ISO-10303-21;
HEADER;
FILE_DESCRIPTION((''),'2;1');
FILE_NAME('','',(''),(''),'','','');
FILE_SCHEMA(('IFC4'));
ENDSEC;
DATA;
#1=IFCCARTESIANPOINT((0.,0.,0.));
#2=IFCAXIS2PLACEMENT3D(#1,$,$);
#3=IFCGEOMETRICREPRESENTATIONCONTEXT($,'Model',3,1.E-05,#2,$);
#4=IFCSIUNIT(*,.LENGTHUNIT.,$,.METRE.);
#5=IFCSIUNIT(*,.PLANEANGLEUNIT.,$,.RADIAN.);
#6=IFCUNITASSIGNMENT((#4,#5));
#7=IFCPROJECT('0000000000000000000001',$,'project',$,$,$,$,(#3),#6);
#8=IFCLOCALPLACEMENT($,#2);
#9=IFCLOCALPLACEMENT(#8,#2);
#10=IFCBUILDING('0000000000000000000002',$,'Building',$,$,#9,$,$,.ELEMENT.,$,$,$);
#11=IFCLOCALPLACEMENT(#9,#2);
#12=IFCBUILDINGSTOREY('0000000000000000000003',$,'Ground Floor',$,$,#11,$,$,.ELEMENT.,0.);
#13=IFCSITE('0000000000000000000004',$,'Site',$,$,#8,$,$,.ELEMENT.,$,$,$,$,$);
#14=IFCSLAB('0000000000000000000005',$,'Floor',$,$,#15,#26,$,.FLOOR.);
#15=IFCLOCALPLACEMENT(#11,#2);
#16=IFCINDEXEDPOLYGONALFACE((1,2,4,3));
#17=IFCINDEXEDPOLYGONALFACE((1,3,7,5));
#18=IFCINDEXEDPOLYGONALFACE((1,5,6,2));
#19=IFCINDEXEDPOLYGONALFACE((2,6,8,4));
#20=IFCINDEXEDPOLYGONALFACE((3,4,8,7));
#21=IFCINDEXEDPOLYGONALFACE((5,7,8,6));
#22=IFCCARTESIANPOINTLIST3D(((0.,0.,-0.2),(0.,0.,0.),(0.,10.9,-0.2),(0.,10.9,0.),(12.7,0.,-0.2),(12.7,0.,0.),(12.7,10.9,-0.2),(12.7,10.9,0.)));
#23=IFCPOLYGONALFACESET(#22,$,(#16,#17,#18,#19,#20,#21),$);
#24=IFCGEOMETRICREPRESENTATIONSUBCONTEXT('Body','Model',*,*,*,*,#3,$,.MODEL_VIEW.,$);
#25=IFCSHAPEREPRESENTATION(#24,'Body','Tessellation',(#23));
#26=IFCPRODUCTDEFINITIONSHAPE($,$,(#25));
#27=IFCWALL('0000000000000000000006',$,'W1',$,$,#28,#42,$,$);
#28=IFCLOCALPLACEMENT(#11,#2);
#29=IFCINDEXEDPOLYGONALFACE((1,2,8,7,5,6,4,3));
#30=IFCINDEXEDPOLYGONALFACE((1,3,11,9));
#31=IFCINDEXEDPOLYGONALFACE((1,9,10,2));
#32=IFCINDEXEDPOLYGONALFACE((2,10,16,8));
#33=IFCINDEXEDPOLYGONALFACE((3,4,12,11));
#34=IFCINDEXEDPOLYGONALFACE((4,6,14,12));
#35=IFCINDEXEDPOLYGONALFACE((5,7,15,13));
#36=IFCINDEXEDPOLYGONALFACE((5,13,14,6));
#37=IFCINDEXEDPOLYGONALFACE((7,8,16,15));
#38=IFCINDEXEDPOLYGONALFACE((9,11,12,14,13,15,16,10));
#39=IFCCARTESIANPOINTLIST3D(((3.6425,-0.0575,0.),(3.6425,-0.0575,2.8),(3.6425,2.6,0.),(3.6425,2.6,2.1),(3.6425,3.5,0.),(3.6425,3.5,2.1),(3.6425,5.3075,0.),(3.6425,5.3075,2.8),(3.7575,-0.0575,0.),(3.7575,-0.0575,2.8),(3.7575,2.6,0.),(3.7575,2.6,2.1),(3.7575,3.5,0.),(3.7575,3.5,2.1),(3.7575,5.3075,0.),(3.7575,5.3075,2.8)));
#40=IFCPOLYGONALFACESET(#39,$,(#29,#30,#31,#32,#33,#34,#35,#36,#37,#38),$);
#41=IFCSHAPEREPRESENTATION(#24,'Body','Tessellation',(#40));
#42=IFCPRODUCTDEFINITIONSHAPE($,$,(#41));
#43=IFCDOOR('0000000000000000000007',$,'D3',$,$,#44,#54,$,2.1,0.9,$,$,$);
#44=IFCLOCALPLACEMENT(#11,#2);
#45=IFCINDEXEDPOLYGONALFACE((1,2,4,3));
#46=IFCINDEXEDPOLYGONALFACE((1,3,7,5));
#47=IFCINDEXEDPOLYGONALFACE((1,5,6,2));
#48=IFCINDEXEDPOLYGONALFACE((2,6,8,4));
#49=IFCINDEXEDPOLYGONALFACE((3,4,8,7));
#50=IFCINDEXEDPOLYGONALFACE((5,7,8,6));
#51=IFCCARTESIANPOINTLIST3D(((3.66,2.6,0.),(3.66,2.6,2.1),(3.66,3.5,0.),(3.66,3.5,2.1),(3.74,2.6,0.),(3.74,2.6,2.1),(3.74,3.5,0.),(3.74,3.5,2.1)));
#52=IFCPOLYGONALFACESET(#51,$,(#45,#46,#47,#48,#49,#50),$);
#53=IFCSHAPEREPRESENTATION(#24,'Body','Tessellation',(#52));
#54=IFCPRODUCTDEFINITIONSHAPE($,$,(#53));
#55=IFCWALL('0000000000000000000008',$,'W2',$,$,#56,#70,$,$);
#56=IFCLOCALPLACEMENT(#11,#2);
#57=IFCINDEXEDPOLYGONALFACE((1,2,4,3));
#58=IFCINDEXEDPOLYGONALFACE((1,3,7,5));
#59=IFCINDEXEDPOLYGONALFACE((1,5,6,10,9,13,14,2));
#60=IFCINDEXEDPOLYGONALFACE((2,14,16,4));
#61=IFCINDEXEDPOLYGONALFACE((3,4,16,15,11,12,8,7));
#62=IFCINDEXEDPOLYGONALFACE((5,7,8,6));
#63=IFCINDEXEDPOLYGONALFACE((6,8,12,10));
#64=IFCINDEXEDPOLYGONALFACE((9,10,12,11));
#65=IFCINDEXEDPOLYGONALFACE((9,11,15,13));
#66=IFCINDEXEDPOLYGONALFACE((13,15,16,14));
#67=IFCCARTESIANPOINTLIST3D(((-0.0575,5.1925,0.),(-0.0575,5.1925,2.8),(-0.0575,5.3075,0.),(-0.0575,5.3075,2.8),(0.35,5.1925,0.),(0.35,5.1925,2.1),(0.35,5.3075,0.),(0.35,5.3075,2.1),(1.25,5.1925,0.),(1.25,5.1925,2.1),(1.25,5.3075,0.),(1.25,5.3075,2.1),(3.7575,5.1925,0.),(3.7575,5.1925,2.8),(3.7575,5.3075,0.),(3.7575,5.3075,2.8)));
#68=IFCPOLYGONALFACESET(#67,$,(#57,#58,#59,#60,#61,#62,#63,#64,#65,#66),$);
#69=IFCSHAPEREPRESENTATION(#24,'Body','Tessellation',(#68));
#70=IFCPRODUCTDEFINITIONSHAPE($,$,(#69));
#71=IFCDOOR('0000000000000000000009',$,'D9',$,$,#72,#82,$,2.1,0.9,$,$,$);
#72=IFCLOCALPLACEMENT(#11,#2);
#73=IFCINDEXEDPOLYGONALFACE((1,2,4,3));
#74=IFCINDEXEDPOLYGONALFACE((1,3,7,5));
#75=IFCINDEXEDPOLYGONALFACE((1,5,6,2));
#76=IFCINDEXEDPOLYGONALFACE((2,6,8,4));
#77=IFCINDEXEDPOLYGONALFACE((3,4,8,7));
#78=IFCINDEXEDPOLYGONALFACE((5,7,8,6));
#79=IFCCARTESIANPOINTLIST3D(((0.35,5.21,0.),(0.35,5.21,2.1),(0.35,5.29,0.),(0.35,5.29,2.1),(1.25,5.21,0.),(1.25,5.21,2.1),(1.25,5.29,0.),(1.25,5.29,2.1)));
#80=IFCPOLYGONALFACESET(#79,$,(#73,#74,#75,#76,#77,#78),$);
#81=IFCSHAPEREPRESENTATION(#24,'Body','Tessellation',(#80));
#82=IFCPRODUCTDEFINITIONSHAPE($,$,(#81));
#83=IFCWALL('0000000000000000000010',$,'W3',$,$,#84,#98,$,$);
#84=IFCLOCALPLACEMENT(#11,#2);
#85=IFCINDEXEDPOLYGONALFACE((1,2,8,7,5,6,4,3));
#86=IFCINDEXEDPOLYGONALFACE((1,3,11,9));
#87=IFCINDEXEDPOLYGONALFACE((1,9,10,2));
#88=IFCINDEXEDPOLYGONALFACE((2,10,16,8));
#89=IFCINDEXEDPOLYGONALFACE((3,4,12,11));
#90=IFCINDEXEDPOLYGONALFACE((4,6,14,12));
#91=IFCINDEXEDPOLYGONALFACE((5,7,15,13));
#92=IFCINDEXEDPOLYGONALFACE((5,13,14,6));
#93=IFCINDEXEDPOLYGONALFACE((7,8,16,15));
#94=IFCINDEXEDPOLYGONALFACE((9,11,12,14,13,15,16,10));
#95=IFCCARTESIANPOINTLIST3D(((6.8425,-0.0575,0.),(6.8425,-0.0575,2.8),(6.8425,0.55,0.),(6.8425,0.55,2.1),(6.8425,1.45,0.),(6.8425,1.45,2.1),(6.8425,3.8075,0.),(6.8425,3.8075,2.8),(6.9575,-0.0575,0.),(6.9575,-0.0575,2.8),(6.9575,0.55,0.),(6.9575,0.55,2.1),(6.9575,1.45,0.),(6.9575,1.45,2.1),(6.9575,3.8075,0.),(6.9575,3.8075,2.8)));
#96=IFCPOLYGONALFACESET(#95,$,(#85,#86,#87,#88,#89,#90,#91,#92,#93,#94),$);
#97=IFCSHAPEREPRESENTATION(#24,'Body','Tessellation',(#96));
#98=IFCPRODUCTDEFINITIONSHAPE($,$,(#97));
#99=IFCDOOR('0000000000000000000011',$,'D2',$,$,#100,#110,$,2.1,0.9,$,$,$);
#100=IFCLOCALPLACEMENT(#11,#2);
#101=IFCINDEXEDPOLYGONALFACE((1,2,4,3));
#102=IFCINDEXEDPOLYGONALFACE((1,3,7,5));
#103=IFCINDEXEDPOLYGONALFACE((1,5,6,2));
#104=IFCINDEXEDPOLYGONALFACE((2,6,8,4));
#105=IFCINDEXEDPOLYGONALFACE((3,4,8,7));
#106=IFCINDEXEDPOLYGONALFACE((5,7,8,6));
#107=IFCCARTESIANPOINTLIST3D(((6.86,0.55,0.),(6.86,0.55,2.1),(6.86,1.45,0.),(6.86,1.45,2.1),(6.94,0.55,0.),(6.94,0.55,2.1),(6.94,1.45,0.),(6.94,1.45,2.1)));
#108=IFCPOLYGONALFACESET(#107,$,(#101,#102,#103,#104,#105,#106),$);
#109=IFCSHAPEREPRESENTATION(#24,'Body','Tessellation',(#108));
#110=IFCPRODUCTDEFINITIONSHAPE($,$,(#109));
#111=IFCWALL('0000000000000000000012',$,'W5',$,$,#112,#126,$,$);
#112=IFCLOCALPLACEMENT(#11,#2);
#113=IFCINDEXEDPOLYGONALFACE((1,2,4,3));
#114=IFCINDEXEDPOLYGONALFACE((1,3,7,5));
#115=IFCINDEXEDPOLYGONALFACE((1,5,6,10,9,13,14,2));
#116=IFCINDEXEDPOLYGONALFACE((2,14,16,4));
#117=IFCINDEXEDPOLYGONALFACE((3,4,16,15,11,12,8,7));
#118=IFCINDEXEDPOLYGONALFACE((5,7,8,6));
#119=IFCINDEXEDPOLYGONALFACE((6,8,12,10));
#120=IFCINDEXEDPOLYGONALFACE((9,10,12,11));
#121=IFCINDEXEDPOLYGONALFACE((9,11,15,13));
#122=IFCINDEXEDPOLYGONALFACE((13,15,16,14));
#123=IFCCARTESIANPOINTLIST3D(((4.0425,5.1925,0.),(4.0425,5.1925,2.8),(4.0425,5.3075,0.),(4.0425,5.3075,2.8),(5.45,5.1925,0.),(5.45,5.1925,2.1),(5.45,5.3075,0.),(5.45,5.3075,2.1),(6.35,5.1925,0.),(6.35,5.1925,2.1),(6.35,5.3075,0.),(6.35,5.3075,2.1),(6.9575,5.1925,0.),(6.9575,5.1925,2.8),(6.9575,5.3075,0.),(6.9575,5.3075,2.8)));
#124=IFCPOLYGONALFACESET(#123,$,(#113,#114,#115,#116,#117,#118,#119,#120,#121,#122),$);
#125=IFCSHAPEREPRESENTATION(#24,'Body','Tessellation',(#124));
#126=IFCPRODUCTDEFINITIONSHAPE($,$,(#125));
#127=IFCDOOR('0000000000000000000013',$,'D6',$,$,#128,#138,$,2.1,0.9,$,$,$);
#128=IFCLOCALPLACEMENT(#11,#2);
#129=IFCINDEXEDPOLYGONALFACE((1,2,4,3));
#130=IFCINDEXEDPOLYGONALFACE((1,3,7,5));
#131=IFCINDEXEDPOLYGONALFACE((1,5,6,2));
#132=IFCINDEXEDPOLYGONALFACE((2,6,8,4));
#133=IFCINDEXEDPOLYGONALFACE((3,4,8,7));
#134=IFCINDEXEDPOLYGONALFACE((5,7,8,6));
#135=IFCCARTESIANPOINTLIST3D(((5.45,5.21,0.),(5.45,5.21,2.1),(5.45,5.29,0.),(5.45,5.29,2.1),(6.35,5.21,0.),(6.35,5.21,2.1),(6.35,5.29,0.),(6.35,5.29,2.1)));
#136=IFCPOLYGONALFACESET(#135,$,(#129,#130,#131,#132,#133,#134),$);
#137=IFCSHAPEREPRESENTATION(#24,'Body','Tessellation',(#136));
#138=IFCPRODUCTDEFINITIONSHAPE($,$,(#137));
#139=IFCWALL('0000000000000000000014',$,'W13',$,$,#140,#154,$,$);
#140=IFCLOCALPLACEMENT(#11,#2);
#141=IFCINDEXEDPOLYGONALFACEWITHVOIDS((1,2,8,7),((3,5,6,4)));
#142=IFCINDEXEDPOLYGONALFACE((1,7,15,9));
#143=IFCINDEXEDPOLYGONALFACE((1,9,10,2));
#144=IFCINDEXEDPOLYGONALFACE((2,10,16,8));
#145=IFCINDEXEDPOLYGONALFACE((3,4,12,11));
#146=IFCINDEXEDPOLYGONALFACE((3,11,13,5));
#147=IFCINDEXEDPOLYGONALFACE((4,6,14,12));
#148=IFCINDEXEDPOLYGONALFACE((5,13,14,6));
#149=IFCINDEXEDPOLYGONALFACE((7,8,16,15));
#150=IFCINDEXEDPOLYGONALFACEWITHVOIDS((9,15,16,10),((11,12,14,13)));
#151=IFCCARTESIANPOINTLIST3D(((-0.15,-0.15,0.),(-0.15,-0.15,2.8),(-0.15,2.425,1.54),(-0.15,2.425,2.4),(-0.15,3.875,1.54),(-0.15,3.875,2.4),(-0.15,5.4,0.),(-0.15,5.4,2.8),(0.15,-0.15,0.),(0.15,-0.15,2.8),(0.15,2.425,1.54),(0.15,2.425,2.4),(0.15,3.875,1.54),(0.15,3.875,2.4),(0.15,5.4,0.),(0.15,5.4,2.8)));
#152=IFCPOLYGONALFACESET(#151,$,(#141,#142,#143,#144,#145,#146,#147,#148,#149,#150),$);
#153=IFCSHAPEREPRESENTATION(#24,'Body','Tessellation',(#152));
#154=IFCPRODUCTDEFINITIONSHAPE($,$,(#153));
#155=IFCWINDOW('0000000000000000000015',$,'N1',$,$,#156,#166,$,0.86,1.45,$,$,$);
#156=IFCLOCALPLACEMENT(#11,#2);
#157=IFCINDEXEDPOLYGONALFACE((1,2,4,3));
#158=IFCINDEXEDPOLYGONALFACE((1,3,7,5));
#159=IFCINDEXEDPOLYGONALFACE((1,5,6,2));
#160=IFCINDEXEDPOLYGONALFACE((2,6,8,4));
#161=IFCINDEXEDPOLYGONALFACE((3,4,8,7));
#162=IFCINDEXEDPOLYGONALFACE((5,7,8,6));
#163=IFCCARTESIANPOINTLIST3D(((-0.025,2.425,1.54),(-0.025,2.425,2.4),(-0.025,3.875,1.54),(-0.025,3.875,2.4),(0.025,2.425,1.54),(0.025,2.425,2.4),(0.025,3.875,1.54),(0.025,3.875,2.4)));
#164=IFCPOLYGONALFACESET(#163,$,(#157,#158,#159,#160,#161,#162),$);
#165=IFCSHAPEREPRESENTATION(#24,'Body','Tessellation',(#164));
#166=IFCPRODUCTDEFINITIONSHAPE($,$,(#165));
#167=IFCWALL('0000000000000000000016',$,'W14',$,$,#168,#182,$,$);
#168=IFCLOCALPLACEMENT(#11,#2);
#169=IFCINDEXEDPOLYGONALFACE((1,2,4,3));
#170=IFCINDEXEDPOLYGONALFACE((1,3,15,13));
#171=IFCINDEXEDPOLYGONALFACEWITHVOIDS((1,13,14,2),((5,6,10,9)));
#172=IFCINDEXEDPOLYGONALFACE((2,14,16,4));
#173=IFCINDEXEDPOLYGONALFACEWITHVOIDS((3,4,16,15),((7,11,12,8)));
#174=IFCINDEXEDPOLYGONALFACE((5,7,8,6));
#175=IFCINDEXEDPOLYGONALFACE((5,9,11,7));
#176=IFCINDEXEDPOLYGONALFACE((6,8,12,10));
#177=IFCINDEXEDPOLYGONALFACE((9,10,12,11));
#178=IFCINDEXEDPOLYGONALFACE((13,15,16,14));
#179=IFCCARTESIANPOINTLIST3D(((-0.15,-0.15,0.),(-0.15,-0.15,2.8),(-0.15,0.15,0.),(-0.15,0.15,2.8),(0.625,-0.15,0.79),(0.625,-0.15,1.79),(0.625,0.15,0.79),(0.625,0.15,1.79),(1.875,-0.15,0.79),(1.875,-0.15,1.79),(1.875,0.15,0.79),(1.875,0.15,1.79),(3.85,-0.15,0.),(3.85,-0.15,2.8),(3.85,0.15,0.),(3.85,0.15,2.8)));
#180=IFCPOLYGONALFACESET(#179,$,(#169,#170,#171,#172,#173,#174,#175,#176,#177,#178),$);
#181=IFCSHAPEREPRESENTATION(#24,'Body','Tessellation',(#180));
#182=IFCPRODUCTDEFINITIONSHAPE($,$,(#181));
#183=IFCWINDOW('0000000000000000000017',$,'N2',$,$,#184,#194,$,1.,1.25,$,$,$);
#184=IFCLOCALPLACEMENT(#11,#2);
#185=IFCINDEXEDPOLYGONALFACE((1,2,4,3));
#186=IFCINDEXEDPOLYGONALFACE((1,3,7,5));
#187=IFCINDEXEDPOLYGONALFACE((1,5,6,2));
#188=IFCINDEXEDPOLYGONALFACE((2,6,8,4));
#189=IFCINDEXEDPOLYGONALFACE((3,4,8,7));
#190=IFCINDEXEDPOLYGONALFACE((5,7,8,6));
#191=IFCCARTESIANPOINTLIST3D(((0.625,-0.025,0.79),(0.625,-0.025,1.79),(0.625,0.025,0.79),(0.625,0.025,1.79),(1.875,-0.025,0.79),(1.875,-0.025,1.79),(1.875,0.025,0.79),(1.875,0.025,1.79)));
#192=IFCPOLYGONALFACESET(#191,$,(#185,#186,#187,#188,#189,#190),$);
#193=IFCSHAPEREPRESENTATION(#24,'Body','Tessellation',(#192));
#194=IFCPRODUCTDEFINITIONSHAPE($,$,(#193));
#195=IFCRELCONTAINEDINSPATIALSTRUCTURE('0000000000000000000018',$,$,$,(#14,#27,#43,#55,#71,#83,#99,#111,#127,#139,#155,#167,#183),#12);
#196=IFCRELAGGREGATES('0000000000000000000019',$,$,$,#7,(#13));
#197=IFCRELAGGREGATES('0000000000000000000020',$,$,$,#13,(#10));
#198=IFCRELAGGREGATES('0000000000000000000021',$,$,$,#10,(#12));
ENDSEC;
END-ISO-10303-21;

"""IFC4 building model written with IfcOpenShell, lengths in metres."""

from ifc_helpers import new_model, si_unit, frame, frame_2d, origin, origin_2d, place, context, subcontext, project, spatial, polyline, rectangle, outline, extrude, element, fill, save


model = new_model("IFC4")

# Units and contexts
model_context = context("Model", 3, precision=1e-05, world=origin())
body_context = subcontext(model_context, "Body", "Model", "MODEL_VIEW")
ifc_project = project(units=[si_unit("LENGTHUNIT", "METRE"), si_unit("PLANEANGLEUNIT", "RADIAN")], contexts=[model_context])

# Site, building, storey
site_placement = place(None, origin())
site = spatial("IfcSite", under=ifc_project, at=site_placement, Name="Site", CompositionType="ELEMENT")
building_placement = place(site_placement, origin())
building = spatial("IfcBuilding", under=site, at=building_placement, Name="Building", CompositionType="ELEMENT")
storey_placement = place(building_placement, origin())
storey = spatial("IfcBuildingStorey", under=building, at=storey_placement, Name="Ground Floor", CompositionType="ELEMENT", Elevation=0.0)

# Slab
slab_placement = place(storey_placement, origin())
element("IfcSlab", 1, at=slab_placement, inside=storey, Name="Floor", PredefinedType="FLOOR", context=body_context, shape_type="SweptSolid", body=[
    extrude(outline(polyline([(0.0, 0.0), (12.7, 0.0), (12.7, 10.9), (0.0, 10.9), (0.0, 0.0)])), origin(), (0.0, 0.0, -1.0), 0.2),
])

# Walls, openings, doors
wall_1_placement = place(storey_placement, frame((3.7, 0.0, 0.0), x_axis=(0.0, 1.0, 0.0)))
wall_1 = element("IfcWall", 2, at=wall_1_placement, inside=storey, Name="W1", context=body_context, shape_type="SweptSolid", body=[
    extrude(rectangle(XDim=5.365, YDim=0.115, at=frame_2d((2.625, 0.0))), origin(), (0.0, 0.0, 1.0), 2.8),
])
opening_1_placement = place(wall_1_placement, frame((3.05, 0.0, 0.0)))
opening_1 = element("IfcOpeningElement", 3, at=opening_1_placement, cuts=wall_1, context=body_context, shape_type="SweptSolid", body=[
    extrude(rectangle(XDim=0.9, YDim=0.215, at=origin_2d()), origin(), (0.0, 0.0, 1.0), 2.1),
])
door_1_placement = place(opening_1_placement, origin())
door_1 = element("IfcDoor", 4, at=door_1_placement, inside=storey, Name="D3", OverallHeight=2.1, OverallWidth=0.9, context=body_context, shape_type="SweptSolid", body=[
    extrude(rectangle(XDim=0.9, YDim=0.08, at=origin_2d()), origin(), (0.0, 0.0, 1.0), 2.1),
])
fill(opening_1, door_1)
wall_2_placement = place(storey_placement, frame((0.0, 5.25, 0.0), x_axis=(1.0, 0.0, 0.0)))
wall_2 = element("IfcWall", 5, at=wall_2_placement, inside=storey, Name="W2", context=body_context, shape_type="SweptSolid", body=[
    extrude(rectangle(XDim=3.815, YDim=0.115, at=frame_2d((1.85, 0.0))), origin(), (0.0, 0.0, 1.0), 2.8),
])
opening_2_placement = place(wall_2_placement, frame((0.8, 0.0, 0.0)))
opening_2 = element("IfcOpeningElement", 6, at=opening_2_placement, cuts=wall_2, context=body_context, shape_type="SweptSolid", body=[
    extrude(rectangle(XDim=0.9, YDim=0.215, at=origin_2d()), origin(), (0.0, 0.0, 1.0), 2.1),
])
door_2_placement = place(opening_2_placement, origin())
door_2 = element("IfcDoor", 7, at=door_2_placement, inside=storey, Name="D9", OverallHeight=2.1, OverallWidth=0.9, context=body_context, shape_type="SweptSolid", body=[
    extrude(rectangle(XDim=0.9, YDim=0.08, at=origin_2d()), origin(), (0.0, 0.0, 1.0), 2.1),
])
fill(opening_2, door_2)
wall_3_placement = place(storey_placement, frame((6.9, 0.0, 0.0), x_axis=(0.0, 1.0, 0.0)))
wall_3 = element("IfcWall", 8, at=wall_3_placement, inside=storey, Name="W3", context=body_context, shape_type="SweptSolid", body=[
    extrude(rectangle(XDim=3.865, YDim=0.115, at=frame_2d((1.875, 0.0))), origin(), (0.0, 0.0, 1.0), 2.8),
])
opening_3_placement = place(wall_3_placement, frame((1.0, 0.0, 0.0)))
opening_3 = element("IfcOpeningElement", 9, at=opening_3_placement, cuts=wall_3, context=body_context, shape_type="SweptSolid", body=[
    extrude(rectangle(XDim=0.9, YDim=0.215, at=origin_2d()), origin(), (0.0, 0.0, 1.0), 2.1),
])
door_3_placement = place(opening_3_placement, origin())
door_3 = element("IfcDoor", 10, at=door_3_placement, inside=storey, Name="D2", OverallHeight=2.1, OverallWidth=0.9, context=body_context, shape_type="SweptSolid", body=[
    extrude(rectangle(XDim=0.9, YDim=0.08, at=origin_2d()), origin(), (0.0, 0.0, 1.0), 2.1),
])
fill(opening_3, door_3)
wall_4_placement = place(storey_placement, frame((4.1, 5.25, 0.0), x_axis=(1.0, 0.0, 0.0)))
wall_4 = element("IfcWall", 11, at=wall_4_placement, inside=storey, Name="W5", context=body_context, shape_type="SweptSolid", body=[
    extrude(rectangle(XDim=2.915, YDim=0.115, at=frame_2d((1.4, 0.0))), origin(), (0.0, 0.0, 1.0), 2.8),
])
opening_4_placement = place(wall_4_placement, frame((1.8, 0.0, 0.0)))
opening_4 = element("IfcOpeningElement", 12, at=opening_4_placement, cuts=wall_4, context=body_context, shape_type="SweptSolid", body=[
    extrude(rectangle(XDim=0.9, YDim=0.215, at=origin_2d()), origin(), (0.0, 0.0, 1.0), 2.1),
])
door_4_placement = place(opening_4_placement, origin())
door_4 = element("IfcDoor", 13, at=door_4_placement, inside=storey, Name="D6", OverallHeight=2.1, OverallWidth=0.9, context=body_context, shape_type="SweptSolid", body=[
    extrude(rectangle(XDim=0.9, YDim=0.08, at=origin_2d()), origin(), (0.0, 0.0, 1.0), 2.1),
])
fill(opening_4, door_4)

# Walls, openings, windows
wall_5_placement = place(storey_placement, frame((0.0, 0.0, 0.0), x_axis=(0.0, 1.0, 0.0)))
wall_5 = element("IfcWall", 14, at=wall_5_placement, inside=storey, Name="W13", context=body_context, shape_type="SweptSolid", body=[
    extrude(rectangle(XDim=5.55, YDim=0.3, at=frame_2d((2.625, 0.0))), origin(), (0.0, 0.0, 1.0), 2.8),
])
opening_5_placement = place(wall_5_placement, frame((3.15, 0.0, 1.54)))
opening_5 = element("IfcOpeningElement", 15, at=opening_5_placement, cuts=wall_5, context=body_context, shape_type="SweptSolid", body=[
    extrude(rectangle(XDim=1.45, YDim=0.4, at=origin_2d()), origin(), (0.0, 0.0, 1.0), 0.86),
])
window_1_placement = place(opening_5_placement, origin())
window_1 = element("IfcWindow", 16, at=window_1_placement, inside=storey, Name="N1", OverallHeight=0.86, OverallWidth=1.45, context=body_context, shape_type="SweptSolid", body=[
    extrude(rectangle(XDim=1.45, YDim=0.05, at=origin_2d()), origin(), (0.0, 0.0, 1.0), 0.86),
])
fill(opening_5, window_1)
wall_6_placement = place(storey_placement, frame((0.0, 0.0, 0.0), x_axis=(1.0, 0.0, 0.0)))
wall_6 = element("IfcWall", 17, at=wall_6_placement, inside=storey, Name="W14", context=body_context, shape_type="SweptSolid", body=[
    extrude(rectangle(XDim=4.0, YDim=0.3, at=frame_2d((1.85, 0.0))), origin(), (0.0, 0.0, 1.0), 2.8),
])
opening_6_placement = place(wall_6_placement, frame((1.25, 0.0, 0.79)))
opening_6 = element("IfcOpeningElement", 18, at=opening_6_placement, cuts=wall_6, context=body_context, shape_type="SweptSolid", body=[
    extrude(rectangle(XDim=1.25, YDim=0.4, at=origin_2d()), origin(), (0.0, 0.0, 1.0), 1.0),
])
window_2_placement = place(opening_6_placement, origin())
window_2 = element("IfcWindow", 19, at=window_2_placement, inside=storey, Name="N2", OverallHeight=1.0, OverallWidth=1.25, context=body_context, shape_type="SweptSolid", body=[
    extrude(rectangle(XDim=1.25, YDim=0.05, at=origin_2d()), origin(), (0.0, 0.0, 1.0), 1.0),
])
fill(opening_6, window_2)

save(model, "model.ifc")
